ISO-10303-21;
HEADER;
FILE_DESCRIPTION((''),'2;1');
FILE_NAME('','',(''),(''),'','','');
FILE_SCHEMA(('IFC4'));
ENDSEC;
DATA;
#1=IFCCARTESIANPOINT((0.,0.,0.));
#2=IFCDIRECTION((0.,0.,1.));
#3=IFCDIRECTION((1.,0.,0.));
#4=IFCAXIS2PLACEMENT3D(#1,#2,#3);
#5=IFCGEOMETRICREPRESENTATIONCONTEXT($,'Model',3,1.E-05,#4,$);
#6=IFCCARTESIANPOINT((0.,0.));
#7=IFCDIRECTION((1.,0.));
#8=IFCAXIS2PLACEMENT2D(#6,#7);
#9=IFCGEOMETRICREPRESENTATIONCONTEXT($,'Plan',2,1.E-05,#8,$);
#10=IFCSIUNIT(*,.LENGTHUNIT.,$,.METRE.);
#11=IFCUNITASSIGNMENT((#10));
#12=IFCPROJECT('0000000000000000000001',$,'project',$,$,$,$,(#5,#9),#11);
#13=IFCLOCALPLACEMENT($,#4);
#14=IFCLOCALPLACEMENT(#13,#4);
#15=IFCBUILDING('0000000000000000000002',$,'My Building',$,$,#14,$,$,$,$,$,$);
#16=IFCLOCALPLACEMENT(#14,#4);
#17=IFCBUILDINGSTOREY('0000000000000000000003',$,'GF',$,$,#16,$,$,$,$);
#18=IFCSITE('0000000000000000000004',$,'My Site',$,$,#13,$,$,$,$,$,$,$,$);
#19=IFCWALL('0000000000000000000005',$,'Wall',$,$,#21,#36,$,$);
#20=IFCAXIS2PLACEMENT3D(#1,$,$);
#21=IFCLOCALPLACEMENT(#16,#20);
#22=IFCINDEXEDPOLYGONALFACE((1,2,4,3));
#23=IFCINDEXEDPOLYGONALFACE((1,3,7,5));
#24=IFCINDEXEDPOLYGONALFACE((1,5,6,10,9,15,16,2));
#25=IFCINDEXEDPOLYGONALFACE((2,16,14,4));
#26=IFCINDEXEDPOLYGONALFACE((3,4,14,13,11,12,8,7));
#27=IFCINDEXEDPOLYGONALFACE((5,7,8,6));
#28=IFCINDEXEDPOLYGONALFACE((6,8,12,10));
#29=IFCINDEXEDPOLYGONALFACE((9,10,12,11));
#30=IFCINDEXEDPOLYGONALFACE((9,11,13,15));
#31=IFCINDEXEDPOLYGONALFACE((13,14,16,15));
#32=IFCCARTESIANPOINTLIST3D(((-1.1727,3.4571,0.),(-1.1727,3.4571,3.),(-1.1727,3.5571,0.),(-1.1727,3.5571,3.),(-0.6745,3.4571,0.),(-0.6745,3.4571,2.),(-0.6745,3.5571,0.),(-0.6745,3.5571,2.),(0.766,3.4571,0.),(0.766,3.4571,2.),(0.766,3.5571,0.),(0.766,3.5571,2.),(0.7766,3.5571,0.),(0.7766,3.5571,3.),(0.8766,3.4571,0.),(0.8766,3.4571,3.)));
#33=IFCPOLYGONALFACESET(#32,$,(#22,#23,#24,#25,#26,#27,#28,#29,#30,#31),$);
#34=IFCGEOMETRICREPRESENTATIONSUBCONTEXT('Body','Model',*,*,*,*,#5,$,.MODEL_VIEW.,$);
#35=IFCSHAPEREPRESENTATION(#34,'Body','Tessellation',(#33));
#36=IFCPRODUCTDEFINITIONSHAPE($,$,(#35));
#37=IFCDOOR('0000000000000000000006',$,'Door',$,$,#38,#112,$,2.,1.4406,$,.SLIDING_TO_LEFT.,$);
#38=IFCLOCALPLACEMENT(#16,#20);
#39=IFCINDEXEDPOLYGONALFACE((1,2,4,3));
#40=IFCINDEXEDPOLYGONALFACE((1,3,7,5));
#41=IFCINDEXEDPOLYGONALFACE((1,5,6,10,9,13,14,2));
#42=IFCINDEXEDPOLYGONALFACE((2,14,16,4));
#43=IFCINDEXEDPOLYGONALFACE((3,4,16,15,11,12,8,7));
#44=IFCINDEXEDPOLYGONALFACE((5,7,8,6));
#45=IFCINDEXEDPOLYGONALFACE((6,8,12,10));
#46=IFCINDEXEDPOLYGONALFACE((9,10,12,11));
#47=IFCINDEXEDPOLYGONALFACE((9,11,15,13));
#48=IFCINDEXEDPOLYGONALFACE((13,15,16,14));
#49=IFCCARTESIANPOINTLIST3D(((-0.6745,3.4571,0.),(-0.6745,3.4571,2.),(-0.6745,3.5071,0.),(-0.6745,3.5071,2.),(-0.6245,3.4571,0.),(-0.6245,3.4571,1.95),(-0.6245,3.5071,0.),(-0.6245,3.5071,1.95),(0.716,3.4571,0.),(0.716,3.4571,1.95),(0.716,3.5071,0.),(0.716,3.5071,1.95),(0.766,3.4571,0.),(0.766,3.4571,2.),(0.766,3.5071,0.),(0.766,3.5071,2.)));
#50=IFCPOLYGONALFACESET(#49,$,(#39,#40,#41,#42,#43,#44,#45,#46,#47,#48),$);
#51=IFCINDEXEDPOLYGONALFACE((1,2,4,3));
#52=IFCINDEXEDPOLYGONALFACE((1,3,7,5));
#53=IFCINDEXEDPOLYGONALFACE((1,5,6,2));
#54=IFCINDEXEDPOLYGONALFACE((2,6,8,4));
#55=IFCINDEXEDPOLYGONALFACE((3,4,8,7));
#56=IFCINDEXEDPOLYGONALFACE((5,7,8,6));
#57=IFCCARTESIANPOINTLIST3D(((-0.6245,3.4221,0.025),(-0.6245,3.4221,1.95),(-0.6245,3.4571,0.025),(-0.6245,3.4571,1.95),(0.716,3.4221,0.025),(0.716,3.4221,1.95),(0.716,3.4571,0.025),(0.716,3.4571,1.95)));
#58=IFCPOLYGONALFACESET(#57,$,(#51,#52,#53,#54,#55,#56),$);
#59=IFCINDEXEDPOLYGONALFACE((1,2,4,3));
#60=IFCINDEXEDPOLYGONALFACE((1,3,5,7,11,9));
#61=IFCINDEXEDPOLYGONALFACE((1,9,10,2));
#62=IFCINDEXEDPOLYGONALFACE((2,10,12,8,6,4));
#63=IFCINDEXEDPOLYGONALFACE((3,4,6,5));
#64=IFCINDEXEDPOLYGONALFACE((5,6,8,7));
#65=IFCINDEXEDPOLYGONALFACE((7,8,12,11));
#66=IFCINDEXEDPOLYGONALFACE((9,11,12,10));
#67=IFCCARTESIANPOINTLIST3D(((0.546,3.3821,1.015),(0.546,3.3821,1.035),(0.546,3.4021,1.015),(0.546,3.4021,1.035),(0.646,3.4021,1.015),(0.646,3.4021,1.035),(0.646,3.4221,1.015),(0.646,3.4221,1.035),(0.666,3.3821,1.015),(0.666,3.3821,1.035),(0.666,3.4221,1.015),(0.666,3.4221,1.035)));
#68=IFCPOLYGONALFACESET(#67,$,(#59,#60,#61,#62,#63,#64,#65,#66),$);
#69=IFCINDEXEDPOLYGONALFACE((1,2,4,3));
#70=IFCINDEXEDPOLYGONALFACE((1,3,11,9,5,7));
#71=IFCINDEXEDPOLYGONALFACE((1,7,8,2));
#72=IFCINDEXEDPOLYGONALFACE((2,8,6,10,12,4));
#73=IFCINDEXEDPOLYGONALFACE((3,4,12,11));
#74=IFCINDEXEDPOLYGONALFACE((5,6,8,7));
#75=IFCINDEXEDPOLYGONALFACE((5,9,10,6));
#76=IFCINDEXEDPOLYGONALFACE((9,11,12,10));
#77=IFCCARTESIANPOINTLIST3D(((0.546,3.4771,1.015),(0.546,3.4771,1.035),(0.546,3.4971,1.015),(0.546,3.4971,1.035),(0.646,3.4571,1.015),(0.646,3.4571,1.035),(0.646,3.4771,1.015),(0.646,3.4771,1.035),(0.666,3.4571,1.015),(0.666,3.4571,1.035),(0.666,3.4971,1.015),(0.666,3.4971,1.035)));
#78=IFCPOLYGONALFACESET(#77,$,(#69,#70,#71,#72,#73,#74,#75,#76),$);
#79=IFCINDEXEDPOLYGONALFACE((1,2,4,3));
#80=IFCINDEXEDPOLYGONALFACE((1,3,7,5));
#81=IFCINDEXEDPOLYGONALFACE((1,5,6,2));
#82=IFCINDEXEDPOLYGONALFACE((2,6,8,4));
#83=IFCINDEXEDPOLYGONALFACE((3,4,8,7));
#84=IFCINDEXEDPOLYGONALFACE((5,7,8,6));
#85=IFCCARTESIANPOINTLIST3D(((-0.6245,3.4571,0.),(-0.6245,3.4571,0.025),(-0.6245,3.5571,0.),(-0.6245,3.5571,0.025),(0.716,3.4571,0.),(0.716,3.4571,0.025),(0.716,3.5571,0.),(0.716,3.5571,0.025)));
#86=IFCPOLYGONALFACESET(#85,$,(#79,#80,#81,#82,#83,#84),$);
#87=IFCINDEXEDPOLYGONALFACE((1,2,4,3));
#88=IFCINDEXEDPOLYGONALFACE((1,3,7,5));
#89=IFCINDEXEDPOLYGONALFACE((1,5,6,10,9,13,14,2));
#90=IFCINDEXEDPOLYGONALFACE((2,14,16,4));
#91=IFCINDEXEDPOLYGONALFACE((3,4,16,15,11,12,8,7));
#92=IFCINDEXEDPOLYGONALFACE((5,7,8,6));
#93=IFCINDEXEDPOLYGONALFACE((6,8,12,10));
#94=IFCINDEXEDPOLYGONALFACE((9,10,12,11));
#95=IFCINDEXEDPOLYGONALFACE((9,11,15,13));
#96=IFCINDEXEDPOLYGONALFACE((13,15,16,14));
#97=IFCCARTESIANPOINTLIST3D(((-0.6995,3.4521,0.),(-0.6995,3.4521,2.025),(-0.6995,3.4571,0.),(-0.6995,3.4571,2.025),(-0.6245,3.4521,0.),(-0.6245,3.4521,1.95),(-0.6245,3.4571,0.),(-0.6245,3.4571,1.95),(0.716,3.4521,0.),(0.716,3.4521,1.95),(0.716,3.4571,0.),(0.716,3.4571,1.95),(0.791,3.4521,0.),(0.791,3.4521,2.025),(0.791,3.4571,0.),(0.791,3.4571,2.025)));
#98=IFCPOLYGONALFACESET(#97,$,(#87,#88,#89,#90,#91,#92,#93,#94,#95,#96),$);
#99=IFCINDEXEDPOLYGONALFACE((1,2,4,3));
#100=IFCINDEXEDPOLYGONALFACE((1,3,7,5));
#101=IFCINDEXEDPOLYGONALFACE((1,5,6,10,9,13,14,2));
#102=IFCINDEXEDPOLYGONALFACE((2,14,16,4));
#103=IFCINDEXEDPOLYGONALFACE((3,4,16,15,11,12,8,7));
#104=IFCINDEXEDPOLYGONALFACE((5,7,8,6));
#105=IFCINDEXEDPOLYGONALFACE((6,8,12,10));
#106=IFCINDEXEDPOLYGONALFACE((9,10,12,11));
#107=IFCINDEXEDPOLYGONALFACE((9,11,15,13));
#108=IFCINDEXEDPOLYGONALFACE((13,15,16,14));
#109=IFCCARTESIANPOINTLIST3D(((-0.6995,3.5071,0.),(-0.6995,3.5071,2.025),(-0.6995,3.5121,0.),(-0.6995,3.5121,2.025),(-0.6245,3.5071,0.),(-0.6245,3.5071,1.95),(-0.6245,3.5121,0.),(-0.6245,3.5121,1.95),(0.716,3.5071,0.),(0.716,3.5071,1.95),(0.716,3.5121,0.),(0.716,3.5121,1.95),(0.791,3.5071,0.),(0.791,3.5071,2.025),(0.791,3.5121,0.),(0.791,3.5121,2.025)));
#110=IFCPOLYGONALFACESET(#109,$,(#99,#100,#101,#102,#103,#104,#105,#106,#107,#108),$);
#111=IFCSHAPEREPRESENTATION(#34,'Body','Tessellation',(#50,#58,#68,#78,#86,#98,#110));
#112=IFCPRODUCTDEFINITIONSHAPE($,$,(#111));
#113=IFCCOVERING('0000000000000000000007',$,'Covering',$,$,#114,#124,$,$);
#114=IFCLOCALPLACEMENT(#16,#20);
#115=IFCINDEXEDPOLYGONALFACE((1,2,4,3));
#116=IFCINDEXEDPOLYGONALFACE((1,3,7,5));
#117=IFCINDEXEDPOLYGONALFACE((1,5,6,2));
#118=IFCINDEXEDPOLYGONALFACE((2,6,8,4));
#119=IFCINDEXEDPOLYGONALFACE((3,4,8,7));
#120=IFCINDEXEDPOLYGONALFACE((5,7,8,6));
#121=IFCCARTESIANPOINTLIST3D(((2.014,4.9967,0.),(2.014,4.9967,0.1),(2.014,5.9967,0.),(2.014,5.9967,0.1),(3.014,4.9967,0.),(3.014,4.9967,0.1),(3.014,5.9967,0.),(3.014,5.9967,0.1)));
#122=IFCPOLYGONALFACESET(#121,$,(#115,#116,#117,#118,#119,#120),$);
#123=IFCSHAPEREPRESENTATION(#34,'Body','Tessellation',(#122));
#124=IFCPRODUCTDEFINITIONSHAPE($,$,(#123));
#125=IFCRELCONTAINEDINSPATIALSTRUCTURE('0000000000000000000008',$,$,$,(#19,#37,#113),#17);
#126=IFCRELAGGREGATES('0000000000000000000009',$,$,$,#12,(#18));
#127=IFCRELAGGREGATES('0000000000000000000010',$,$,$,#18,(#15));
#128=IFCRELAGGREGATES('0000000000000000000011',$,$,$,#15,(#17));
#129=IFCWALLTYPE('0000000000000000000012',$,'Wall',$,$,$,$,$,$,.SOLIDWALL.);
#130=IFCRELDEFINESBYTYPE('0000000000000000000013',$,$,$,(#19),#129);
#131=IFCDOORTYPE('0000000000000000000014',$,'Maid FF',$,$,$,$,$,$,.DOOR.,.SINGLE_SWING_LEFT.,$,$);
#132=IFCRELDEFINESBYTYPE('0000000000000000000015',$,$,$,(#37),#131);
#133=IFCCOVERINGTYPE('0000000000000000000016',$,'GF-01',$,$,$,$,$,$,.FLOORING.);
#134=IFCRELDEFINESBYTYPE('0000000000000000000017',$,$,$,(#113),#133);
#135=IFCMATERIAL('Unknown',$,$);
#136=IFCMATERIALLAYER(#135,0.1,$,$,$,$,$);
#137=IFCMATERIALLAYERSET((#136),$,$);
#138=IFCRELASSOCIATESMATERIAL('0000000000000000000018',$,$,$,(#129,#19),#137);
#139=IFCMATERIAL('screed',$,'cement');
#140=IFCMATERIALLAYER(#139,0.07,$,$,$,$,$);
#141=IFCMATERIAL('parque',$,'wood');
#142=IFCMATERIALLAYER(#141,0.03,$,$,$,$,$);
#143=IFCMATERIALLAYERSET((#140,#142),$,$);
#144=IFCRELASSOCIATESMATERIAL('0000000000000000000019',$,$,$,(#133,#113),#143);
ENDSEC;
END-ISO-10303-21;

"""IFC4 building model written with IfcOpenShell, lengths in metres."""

from ifc_helpers import new_model, entity, si_unit, frame, origin_with_axes, origin_2d_with_axis, place, context, subcontext, project, spatial, line, indexed_curve, outline, extrude, shape, source, transform, mapped, material, layer, layer_set, layer_usage, type_object, type_shapes, element, fill, save


model = new_model("IFC4")

# Units and contexts
model_context = context("Model", 3, precision=1e-05, world=origin_with_axes())
plan_context = context("Plan", 2, precision=1e-05, world=origin_2d_with_axis())
body_context_1 = subcontext(model_context, "Body", "Model", "MODEL_VIEW")
body_context_2 = subcontext(plan_context, "Body", "Plan", "PLAN_VIEW")
ifc_project = project(units=[si_unit("LENGTHUNIT", "METRE")], contexts=[model_context, plan_context])

# Site, building, storey
site_placement = place(None, origin_with_axes())
site = spatial("IfcSite", under=ifc_project, at=site_placement, Name="My Site")
building_placement = place(site_placement, origin_with_axes())
building = spatial("IfcBuilding", under=site, at=building_placement, Name="My Building")
storey_placement = place(building_placement, origin_with_axes())
storey = spatial("IfcBuildingStorey", under=building, at=storey_placement, Name="GF")

# Shared definitions
ifc_material_1 = material(Name="Unknown")

# Shared definitions
ifc_layer_1 = layer(ifc_material_1, 0.1)
ifc_layer_set_1 = layer_set([ifc_layer_1])
wall_type = type_object("IfcWallType", Name="Wall", PredefinedType="SOLIDWALL", material=ifc_layer_set_1)

# Wall, opening, door
ifc_layer_usage_1 = layer_usage(ifc_layer_set_1, "AXIS2", "POSITIVE", 0.0)
wall_1_placement = place(storey_placement, frame((0.7766, 3.5571, 0.0), z_axis=(0.0, 0.0, 1.0), x_axis=(-1.0, 0.0, 0.0)))
wall_1 = element("IfcWall", 1, at=wall_1_placement, inside=storey, type_object=wall_type, material=ifc_layer_usage_1, Name="Wall", context=body_context_1, shape_type="SweptSolid", body=[
    extrude(outline(indexed_curve([(0.0, 0.0), (-0.1, 0.1), (1.9493, 0.1), (1.9493, 0.0)], segments=[line(1, 2, 3, 4, 1)])), origin_with_axes(), (0.0, 0.0, 1.0), 3.0),
])
shared_shape_1 = source(origin_with_axes(), body_context_1, "Body", "SweptSolid", [
    extrude(outline(indexed_curve([(0.0, 0.0), (1.4406, 0.0), (1.4406, 2.0), (0.0, 2.0)], segments=[line(1, 2, 3, 4, 1)])), frame((0.0, -0.6, 0.0), z_axis=(0.0, -1.0, 0.0), x_axis=(1.0, 0.0, 0.0)), (0.0, 0.0, -1.0), 1.2),
])
opening_1_placement = place(wall_1_placement, frame((1.4511, 0.1, 0.0), z_axis=(0.0, 0.0, 1.0), x_axis=(-1.0, 0.000001, 0.0)))
opening_1 = element("IfcOpeningElement", 2, at=opening_1_placement, cuts=wall_1, PredefinedType="OPENING", context=body_context_1, shape_type="MappedRepresentation", body=[
    mapped(shared_shape_1, transform((0.0, 0.0, 0.0), x_axis=(1.0, 0.0, 0.0), y_axis=(0.0, 1.0, 0.0), z_axis=(0.0, 0.0, 1.0), scale=1.0)),
])
door_type_1 = type_object("IfcDoorType", Name="Maid FF", OperationType="SINGLE_SWING_LEFT", PredefinedType="DOOR")
shared_shape_2 = source(origin_with_axes(), body_context_1, "Body", "SweptSolid", [
    extrude(outline(indexed_curve([(0.0, 0.0), (0.0, 2.0), (1.4406, 2.0), (1.4406, 0.0), (1.3906, 0.0), (1.3906, 1.95), (0.05, 1.95), (0.05, 0.0)], segments=[line(1, 2, 3, 4, 5, 6, 7, 8, 1)])), frame((0.0, 0.0, 0.0), z_axis=(0.0, -1.0, 0.0), x_axis=(1.0, 0.0, 0.0)), (0.0, 0.0, -1.0), 0.05),
    extrude(outline(indexed_curve([(0.0, 0.0), (1.3406, 0.0), (1.3406, 0.035), (0.0, 0.035)], segments=[line(1, 2, 3, 4, 1)])), frame((0.05, -0.035, 0.025), z_axis=(0.0, 0.0, 1.0), x_axis=(1.0, 0.0, 0.0)), (0.0, 0.0, 1.0), 1.925),
    extrude(outline(indexed_curve([(0.0, 0.0), (0.0, -0.04), (-0.12, -0.04), (-0.12, -0.02), (-0.02, -0.02), (-0.02, 0.0)], segments=[line(1, 2, 3, 4, 5, 6, 1)])), frame((1.3406, -0.035, 1.015), z_axis=(0.0, 0.0, 1.0), x_axis=(1.0, 0.0, 0.0)), (0.0, 0.0, 1.0), 0.02),
    extrude(outline(indexed_curve([(0.0, 0.0), (0.0, 0.04), (-0.12, 0.04), (-0.12, 0.02), (-0.02, 0.02), (-0.02, 0.0)], segments=[line(1, 2, 3, 4, 5, 6, 1)])), frame((1.3406, 0.0, 1.015), z_axis=(0.0, 0.0, 1.0), x_axis=(1.0, 0.0, 0.0)), (0.0, 0.0, 1.0), 0.02),
    extrude(outline(indexed_curve([(0.0, 0.0), (1.3406, 0.0), (1.3406, 0.1), (0.0, 0.1)], segments=[line(1, 2, 3, 4, 1)])), frame((0.05, 0.0, 0.0), z_axis=(0.0, 0.0, 1.0), x_axis=(1.0, 0.0, 0.0)), (0.0, 0.0, 1.0), 0.025),
    extrude(outline(indexed_curve([(0.0, 0.0), (0.0, 2.025), (1.4906, 2.025), (1.4906, 0.0), (1.4156, 0.0), (1.4156, 1.95), (0.075, 1.95), (0.075, 0.0)], segments=[line(1, 2, 3, 4, 5, 6, 7, 8, 1)])), frame((-0.025, -0.005, 0.0), z_axis=(0.0, -1.0, 0.0), x_axis=(1.0, 0.0, 0.0)), (0.0, 0.0, -1.0), 0.005),
    extrude(outline(indexed_curve([(0.0, 0.0), (0.0, 2.025), (1.4906, 2.025), (1.4906, 0.0), (1.4156, 0.0), (1.4156, 1.95), (0.075, 1.95), (0.075, 0.0)], segments=[line(1, 2, 3, 4, 5, 6, 7, 8, 1)])), frame((-0.025, 0.05, 0.0), z_axis=(0.0, -1.0, 0.0), x_axis=(1.0, 0.0, 0.0)), (0.0, 0.0, -1.0), 0.005),
])
shared_shape_3 = source(origin_with_axes(), body_context_2, "Body", "Curve2D", [
    entity("IfcIndexedPolyCurve", entity("IfcCartesianPointList2D", [[0.0, 0.0], [0.05, 0.0], [0.05, 0.05], [0.0, 0.05]]), [entity("IfcLineIndex", [1, 2, 3, 4, 1])]),
    entity("IfcIndexedPolyCurve", entity("IfcCartesianPointList2D", [[1.4406, 0.0], [1.3906, 0.0], [1.3906, 0.05], [1.4406, 0.05]]), [entity("IfcLineIndex", [1, 2, 3, 4, 1])]),
    entity("IfcIndexedPolyCurve", entity("IfcCartesianPointList2D", [[-0.6203, -0.035], [0.7203, -0.035], [0.7203, 0.0], [-0.6203, 0.0]]), [entity("IfcLineIndex", [1, 2, 3, 4, 1])]),
])
type_shapes(door_type_1, [shared_shape_2, shared_shape_3])
door_1_placement = place(opening_1_placement, frame((0.0, 0.0, 0.0), z_axis=(0.0, 0.0, 1.0), x_axis=(1.0, 0.0, 0.0)))
door_1 = element("IfcDoor", 3, at=door_1_placement, inside=storey, type_object=door_type_1, Name="Door", OperationType="SLIDING_TO_LEFT", OverallHeight=2.0, OverallWidth=1.4406, shapes=[
    shape(body_context_1, "Body", "MappedRepresentation", [mapped(shared_shape_2, transform((0.0, 0.0, 0.0), x_axis=(1.0, 0.0, 0.0), y_axis=(0.0, 1.0, 0.0), z_axis=(0.0, 0.0, 1.0), scale=1.0))]),
    shape(body_context_2, "Body", "MappedRepresentation", [mapped(shared_shape_3, transform((0.0, 0.0, 0.0), x_axis=(1.0, 0.0, 0.0), y_axis=(0.0, 1.0, 0.0), z_axis=(0.0, 0.0, 1.0), scale=1.0))]),
])
fill(opening_1, door_1)

# Covering
ifc_material_2 = material(Name="screed", Category="cement")
ifc_layer_2 = layer(ifc_material_2, 0.07)
ifc_material_3 = material(Name="parque", Category="wood")
ifc_layer_3 = layer(ifc_material_3, 0.03)
ifc_layer_set_2 = layer_set([ifc_layer_2, ifc_layer_3])
ifc_layer_usage_2 = layer_usage(ifc_layer_set_2, "AXIS3", "POSITIVE", 0.0)
covering_type = type_object("IfcCoveringType", Name="GF-01", PredefinedType="FLOORING", material=ifc_layer_set_2)
covering_placement = place(storey_placement, frame((2.014, 4.9967, 0.0), z_axis=(0.0, 0.0, 1.0), x_axis=(1.0, 0.0, 0.0)))
element("IfcCovering", 4, at=covering_placement, inside=storey, type_object=covering_type, material=ifc_layer_usage_2, Name="Covering", context=body_context_1, shape_type="SweptSolid", body=[
    extrude(outline(indexed_curve([(0.0, 0.0), (1.0, 0.0), (1.0, 1.0), (0.0, 1.0), (0.0, 0.0)])), origin_with_axes(), (0.0, 0.0, 1.0), 0.1),
])

save(model, "model.ifc")
